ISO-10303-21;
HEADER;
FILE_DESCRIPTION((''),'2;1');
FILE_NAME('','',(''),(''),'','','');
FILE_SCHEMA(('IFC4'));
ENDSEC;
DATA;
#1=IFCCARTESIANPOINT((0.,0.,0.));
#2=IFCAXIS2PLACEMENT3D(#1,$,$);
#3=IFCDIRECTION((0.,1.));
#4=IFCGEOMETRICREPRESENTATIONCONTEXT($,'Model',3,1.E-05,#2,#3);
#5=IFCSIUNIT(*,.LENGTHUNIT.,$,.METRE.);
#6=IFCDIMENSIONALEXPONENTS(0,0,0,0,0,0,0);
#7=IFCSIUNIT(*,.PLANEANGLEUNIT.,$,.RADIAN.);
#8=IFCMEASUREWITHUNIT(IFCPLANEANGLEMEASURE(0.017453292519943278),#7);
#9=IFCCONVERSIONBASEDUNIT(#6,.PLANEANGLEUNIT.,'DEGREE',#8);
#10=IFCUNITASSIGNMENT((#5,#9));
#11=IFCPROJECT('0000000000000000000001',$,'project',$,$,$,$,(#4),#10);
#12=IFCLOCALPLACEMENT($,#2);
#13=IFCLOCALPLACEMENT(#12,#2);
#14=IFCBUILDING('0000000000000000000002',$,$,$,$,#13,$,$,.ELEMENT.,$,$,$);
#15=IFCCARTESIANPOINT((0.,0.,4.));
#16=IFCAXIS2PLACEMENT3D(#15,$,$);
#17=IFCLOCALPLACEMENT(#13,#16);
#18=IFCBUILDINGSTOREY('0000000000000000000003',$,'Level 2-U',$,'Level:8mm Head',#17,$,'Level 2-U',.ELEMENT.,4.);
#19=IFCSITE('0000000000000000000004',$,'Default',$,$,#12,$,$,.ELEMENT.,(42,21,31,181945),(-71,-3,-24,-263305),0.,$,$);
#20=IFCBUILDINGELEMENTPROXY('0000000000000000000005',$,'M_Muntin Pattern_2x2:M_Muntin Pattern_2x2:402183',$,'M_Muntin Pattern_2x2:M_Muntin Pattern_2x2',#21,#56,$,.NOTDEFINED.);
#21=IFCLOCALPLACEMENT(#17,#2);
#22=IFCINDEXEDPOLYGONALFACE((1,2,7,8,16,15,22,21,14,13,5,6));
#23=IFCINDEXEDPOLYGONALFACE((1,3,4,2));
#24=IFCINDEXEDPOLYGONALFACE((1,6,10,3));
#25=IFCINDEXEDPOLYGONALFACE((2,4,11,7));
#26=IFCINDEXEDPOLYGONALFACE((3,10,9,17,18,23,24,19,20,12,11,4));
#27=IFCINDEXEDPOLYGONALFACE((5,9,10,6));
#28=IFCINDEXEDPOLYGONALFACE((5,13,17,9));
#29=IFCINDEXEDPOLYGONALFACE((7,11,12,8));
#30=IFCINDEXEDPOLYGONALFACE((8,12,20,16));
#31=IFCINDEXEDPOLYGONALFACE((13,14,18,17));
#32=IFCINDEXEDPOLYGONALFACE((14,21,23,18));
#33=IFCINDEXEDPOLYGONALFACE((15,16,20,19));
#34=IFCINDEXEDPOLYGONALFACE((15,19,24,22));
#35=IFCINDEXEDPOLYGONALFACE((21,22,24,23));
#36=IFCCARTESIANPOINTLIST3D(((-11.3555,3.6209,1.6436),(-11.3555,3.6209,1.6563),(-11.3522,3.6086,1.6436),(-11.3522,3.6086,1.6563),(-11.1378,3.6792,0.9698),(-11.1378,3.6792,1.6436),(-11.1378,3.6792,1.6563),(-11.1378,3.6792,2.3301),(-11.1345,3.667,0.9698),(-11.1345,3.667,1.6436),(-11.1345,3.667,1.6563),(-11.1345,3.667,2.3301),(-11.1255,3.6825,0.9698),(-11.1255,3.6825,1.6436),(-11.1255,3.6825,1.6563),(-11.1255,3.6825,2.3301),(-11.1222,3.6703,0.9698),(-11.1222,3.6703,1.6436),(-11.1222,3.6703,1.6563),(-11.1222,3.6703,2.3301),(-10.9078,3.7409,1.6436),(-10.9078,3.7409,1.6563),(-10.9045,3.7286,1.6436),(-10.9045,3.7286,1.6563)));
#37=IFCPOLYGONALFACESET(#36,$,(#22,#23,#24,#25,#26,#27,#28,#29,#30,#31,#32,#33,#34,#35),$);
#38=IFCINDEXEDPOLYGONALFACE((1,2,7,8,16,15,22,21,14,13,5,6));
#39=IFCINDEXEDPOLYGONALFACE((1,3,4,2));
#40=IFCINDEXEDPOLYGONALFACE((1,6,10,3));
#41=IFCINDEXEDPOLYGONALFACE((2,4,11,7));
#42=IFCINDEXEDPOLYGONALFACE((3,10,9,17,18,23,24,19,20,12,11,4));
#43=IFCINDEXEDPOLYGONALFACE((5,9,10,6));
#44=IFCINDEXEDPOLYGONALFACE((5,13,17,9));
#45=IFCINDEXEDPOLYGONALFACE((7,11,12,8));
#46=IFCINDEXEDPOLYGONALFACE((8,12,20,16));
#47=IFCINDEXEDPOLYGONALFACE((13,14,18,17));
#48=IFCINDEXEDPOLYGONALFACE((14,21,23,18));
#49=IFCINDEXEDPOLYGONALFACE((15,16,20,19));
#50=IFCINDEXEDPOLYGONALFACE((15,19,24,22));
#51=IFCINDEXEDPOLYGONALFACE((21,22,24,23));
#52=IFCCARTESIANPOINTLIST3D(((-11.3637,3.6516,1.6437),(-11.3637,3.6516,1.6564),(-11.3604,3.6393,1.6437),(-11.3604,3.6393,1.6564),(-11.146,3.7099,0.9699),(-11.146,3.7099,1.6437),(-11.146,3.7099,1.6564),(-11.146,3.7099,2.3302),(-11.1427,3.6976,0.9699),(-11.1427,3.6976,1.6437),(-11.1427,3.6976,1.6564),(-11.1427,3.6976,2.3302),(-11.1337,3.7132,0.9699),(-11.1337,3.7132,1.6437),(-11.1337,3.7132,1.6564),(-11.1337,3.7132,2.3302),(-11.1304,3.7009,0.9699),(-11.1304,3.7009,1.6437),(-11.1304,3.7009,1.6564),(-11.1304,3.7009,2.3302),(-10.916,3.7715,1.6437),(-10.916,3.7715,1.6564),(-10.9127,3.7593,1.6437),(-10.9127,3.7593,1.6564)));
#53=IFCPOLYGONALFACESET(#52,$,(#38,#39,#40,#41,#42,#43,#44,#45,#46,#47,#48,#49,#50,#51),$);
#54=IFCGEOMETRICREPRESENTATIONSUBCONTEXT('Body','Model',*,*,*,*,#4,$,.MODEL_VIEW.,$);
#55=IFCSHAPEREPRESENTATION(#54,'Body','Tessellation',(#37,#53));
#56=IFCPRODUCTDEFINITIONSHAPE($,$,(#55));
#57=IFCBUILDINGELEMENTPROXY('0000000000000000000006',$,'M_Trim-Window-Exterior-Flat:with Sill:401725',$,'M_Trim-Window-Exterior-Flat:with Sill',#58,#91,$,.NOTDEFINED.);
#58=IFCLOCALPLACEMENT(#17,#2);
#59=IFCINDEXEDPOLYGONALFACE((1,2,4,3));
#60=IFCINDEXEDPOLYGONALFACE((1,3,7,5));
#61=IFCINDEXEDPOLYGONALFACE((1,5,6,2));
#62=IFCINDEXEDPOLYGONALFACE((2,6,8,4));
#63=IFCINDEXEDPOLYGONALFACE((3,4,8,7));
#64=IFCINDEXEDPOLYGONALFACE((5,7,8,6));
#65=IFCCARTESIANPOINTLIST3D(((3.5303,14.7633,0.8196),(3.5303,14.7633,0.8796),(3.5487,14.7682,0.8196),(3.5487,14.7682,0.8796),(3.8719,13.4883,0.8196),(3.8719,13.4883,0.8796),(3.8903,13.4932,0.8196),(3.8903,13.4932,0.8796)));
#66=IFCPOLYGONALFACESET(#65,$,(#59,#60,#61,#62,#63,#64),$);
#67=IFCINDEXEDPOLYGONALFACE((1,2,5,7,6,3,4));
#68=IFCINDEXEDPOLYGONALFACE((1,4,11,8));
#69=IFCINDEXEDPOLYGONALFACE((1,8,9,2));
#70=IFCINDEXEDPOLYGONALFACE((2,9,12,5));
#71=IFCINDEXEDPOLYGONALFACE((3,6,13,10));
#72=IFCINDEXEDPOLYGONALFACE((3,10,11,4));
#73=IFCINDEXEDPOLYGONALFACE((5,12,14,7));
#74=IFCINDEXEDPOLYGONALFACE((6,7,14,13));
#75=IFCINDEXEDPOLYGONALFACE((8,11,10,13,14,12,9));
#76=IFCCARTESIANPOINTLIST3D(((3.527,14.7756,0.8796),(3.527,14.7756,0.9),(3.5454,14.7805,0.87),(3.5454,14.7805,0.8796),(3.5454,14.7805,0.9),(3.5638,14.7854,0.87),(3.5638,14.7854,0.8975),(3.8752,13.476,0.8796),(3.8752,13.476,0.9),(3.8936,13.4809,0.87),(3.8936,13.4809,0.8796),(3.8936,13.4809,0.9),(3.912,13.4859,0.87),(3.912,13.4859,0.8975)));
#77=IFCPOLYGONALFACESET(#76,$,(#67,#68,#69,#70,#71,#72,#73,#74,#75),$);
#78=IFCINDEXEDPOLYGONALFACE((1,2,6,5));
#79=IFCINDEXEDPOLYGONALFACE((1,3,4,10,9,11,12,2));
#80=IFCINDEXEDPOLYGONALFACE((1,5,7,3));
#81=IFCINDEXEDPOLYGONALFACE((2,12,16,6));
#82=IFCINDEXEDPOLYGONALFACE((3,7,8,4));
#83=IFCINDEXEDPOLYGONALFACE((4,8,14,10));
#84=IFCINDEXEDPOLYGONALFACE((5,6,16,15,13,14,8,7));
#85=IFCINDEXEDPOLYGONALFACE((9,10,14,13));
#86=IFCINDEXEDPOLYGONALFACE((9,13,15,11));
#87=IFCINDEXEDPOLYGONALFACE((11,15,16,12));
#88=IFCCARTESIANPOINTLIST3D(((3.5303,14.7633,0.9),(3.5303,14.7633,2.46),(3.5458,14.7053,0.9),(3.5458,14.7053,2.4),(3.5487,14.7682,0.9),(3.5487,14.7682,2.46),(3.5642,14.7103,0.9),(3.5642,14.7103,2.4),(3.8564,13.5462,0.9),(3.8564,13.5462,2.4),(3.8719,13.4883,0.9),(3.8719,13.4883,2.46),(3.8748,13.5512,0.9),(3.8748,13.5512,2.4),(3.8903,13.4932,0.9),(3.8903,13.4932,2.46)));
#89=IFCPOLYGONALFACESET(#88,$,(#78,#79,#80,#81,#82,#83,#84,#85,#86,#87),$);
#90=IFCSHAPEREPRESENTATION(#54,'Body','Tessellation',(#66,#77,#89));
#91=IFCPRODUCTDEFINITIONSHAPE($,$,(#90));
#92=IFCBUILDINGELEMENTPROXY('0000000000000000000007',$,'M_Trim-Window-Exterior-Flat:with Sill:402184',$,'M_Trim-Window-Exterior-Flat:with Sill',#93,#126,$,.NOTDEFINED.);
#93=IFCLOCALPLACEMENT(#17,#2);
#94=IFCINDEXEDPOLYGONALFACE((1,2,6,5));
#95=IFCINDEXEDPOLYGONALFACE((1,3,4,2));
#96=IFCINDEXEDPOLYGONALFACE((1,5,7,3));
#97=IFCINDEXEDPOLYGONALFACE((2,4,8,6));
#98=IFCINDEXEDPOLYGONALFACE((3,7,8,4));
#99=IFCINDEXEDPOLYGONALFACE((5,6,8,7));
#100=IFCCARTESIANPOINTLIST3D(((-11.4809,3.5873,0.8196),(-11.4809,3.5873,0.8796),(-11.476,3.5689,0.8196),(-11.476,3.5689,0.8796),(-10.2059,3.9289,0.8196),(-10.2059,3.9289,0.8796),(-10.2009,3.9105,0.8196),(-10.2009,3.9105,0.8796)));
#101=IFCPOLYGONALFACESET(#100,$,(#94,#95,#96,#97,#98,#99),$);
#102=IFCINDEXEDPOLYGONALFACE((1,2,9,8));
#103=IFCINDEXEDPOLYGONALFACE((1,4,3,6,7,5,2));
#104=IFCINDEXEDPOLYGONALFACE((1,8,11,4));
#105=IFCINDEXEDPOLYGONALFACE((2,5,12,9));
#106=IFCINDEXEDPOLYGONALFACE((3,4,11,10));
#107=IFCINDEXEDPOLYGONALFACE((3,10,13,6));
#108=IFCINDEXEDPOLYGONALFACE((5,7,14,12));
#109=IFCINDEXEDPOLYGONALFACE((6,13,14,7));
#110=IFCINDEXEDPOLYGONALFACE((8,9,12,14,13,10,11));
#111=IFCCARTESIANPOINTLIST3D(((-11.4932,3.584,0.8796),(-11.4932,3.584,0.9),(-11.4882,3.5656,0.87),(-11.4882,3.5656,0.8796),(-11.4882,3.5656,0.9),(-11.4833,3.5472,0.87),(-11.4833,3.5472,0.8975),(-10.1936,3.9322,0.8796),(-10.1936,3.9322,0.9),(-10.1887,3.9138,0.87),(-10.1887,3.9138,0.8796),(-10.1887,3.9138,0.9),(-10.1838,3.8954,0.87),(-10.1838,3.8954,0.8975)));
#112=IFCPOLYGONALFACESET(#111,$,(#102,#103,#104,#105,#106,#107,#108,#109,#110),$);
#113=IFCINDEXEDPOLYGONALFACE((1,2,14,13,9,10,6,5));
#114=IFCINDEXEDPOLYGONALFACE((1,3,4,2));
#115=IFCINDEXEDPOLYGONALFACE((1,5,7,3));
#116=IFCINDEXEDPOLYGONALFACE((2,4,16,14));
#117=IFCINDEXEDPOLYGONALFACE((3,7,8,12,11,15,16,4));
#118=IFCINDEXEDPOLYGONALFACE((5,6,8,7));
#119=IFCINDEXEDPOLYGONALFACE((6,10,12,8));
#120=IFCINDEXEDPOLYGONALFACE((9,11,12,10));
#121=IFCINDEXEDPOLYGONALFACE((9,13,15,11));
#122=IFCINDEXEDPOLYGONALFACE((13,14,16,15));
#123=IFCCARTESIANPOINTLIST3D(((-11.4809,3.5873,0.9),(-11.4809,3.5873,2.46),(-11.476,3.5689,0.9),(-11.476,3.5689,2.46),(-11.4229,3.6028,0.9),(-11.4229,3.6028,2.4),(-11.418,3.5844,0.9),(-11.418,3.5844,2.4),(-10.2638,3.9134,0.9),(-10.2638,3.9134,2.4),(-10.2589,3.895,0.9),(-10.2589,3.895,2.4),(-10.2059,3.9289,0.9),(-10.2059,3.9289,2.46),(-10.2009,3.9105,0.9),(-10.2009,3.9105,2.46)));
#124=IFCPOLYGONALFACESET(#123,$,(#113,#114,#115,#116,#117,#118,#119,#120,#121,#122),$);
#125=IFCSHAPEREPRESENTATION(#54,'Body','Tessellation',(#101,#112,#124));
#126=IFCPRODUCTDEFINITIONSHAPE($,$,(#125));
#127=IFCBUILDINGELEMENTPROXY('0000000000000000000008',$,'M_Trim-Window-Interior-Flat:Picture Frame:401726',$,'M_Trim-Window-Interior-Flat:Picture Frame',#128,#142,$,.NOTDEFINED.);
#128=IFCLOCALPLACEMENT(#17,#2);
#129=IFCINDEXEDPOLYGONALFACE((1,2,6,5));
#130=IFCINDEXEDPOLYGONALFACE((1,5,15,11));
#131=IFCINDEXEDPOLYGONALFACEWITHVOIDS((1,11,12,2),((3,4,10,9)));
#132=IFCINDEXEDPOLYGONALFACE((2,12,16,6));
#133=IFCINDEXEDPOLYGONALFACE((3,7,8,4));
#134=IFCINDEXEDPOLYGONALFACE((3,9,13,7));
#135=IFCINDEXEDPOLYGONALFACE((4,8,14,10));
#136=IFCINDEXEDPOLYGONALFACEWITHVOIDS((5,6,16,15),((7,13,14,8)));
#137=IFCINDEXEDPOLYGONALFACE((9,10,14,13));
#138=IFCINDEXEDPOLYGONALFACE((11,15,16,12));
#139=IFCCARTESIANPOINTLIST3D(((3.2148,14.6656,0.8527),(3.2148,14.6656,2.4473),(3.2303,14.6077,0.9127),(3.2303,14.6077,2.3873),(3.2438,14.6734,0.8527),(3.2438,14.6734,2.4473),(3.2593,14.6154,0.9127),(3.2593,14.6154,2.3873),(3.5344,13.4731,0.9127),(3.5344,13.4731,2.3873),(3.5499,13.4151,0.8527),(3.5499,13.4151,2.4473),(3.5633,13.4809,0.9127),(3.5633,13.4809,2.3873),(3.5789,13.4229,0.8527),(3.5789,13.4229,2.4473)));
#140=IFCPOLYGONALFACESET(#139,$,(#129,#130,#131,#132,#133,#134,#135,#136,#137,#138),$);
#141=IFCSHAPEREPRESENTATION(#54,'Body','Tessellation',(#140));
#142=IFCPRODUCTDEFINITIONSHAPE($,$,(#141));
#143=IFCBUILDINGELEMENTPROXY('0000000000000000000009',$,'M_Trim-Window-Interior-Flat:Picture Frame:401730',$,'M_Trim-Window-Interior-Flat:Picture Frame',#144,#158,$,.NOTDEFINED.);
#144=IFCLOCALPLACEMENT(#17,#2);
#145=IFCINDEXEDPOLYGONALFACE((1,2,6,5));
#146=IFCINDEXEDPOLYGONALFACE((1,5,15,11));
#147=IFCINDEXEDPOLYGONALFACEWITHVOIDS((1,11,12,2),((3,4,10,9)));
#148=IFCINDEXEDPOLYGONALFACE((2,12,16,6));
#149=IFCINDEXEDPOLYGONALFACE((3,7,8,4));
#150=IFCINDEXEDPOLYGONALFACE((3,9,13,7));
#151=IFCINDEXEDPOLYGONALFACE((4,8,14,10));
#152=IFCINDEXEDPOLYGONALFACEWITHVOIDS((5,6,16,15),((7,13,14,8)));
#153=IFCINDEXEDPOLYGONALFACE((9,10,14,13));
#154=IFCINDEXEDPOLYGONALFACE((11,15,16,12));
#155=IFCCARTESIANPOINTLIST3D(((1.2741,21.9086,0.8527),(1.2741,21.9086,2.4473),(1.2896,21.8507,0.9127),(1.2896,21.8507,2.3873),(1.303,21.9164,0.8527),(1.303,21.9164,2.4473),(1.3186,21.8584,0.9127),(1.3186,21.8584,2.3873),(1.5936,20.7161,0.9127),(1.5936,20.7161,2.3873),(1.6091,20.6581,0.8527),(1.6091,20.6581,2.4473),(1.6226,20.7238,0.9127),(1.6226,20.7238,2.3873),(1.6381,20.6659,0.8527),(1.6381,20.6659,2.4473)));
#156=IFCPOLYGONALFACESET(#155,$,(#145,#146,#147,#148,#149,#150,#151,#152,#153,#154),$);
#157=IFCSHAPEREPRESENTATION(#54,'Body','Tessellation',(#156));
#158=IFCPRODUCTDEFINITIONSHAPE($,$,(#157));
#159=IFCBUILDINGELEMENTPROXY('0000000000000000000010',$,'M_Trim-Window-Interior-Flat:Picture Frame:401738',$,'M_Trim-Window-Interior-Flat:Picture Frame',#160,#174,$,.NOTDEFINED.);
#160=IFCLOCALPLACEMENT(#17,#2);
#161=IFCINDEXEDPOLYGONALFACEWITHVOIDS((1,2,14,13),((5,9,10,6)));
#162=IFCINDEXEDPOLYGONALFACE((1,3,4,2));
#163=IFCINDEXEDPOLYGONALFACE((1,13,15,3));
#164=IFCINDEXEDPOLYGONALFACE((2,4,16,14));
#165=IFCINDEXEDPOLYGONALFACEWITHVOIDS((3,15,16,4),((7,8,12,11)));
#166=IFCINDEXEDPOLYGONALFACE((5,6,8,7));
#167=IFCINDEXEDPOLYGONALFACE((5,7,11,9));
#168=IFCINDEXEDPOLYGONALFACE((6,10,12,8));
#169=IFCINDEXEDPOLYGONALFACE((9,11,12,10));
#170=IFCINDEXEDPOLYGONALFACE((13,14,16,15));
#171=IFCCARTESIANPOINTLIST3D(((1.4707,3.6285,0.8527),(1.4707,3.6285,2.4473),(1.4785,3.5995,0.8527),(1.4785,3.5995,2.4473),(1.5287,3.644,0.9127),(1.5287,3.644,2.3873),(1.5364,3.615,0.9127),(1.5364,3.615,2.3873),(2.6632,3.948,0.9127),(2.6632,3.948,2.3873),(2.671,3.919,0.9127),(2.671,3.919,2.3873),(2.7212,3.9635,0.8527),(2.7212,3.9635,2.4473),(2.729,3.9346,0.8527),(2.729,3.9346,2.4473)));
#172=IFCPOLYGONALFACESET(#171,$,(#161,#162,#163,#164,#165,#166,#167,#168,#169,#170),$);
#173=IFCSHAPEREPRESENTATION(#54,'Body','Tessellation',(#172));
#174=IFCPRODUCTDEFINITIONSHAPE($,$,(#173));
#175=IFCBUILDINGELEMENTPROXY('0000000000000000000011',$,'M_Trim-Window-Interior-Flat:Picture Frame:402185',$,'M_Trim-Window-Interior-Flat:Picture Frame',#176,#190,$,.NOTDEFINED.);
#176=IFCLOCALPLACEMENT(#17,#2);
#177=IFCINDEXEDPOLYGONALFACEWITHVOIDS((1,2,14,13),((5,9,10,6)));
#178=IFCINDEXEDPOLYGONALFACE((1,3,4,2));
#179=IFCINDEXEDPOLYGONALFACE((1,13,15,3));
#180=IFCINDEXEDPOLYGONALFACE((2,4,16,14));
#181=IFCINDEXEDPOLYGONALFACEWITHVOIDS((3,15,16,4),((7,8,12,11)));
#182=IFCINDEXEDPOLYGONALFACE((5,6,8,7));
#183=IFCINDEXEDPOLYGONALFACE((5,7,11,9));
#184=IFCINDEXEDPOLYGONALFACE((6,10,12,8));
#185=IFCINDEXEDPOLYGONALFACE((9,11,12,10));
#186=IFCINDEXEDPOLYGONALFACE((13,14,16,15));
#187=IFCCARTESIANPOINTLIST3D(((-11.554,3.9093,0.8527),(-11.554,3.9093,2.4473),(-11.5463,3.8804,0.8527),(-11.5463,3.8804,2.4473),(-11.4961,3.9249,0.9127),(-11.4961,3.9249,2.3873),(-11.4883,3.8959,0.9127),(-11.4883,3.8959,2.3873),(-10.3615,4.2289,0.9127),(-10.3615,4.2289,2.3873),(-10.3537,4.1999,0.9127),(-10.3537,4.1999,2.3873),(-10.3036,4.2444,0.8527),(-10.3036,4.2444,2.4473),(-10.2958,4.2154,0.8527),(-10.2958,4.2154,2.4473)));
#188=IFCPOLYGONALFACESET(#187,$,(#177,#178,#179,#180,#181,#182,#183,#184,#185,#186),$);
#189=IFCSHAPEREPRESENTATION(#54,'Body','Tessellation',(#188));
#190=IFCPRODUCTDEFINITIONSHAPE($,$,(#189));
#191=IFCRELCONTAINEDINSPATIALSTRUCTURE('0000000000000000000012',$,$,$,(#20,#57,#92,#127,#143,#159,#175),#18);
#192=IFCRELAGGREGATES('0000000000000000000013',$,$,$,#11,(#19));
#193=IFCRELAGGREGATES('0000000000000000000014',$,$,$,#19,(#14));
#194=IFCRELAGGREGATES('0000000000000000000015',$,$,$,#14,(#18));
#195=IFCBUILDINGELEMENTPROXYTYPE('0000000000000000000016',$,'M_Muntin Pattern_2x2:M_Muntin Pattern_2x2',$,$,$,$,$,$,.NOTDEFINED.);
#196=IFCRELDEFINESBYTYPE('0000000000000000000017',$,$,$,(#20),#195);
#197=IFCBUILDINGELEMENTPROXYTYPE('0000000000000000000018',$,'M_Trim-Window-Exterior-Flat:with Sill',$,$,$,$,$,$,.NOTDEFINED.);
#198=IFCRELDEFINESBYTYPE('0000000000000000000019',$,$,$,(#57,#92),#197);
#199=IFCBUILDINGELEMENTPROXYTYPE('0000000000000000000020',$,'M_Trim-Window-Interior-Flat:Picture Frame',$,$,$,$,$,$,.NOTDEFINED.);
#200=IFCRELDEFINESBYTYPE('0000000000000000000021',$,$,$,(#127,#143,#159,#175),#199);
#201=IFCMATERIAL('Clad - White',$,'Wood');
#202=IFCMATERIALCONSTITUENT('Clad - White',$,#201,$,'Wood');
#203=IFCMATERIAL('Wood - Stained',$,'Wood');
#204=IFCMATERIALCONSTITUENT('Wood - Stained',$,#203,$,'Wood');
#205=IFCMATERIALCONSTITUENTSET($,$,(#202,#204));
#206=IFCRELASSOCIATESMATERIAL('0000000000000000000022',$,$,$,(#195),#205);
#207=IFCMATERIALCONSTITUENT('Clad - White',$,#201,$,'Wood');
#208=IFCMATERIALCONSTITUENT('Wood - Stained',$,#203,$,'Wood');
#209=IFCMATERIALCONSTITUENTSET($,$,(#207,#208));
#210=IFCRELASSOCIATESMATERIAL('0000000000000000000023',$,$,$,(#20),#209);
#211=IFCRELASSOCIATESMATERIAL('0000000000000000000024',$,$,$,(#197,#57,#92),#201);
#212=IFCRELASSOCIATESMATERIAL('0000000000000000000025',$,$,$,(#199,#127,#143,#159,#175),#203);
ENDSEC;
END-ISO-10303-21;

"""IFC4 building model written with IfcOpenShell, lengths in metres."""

from ifc_helpers import new_model, entity, si_unit, converted_unit, direction, frame, origin, place, context, subcontext, project, spatial, indexed_curve, outline, extrude, source, transform, mapped, material, constituent, constituent_set, type_object, type_shapes, element, save


model = new_model("IFC4")

# Units and contexts
model_context = context("Model", 3, precision=1e-05, world=origin(), true_north=direction((0.0, 1.0)))
body_context = subcontext(model_context, "Body", "Model", "MODEL_VIEW")
ifc_project = project(units=[si_unit("LENGTHUNIT", "METRE"), converted_unit("PLANEANGLEUNIT", "DEGREE", entity("IfcPlaneAngleMeasure", 0.017453292519943278), si_unit("PLANEANGLEUNIT", "RADIAN"), dimensions=[0, 0, 0, 0, 0, 0, 0])], contexts=[model_context])

# Site, building, storey
site_placement = place(None, origin())
site = spatial("IfcSite", under=ifc_project, at=site_placement, Name="Default", CompositionType="ELEMENT", RefLatitude=(42, 21, 31, 181945), RefLongitude=(-71, -3, -24, -263305), RefElevation=0.0)
building_placement = place(site_placement, origin())
building = spatial("IfcBuilding", under=site, at=building_placement, CompositionType="ELEMENT")
storey_placement = place(building_placement, frame((0.0, 0.0, 4.0)))
storey = spatial("IfcBuildingStorey", under=building, at=storey_placement, Name="Level 2-U", ObjectType="Level:8mm Head", LongName="Level 2-U", CompositionType="ELEMENT", Elevation=4.0)

# Building element proxies
ifc_material_1 = material(Name="Clad - White", Category="Wood")
ifc_material_2 = material(Name="Wood - Stained", Category="Wood")
ifc_constituent_1 = constituent(ifc_material_1, Name="Clad - White", Category="Wood")
ifc_constituent_2 = constituent(ifc_material_2, Name="Wood - Stained", Category="Wood")
ifc_constituent_set_1 = constituent_set(constituents=[ifc_constituent_1, ifc_constituent_2])
building_element_proxy_type_1 = type_object("IfcBuildingElementProxyType", Name="M_Muntin Pattern_2x2:M_Muntin Pattern_2x2", PredefinedType="NOTDEFINED", material=ifc_constituent_set_1)
shared_shape_1 = source(origin(), body_context, "Body", "SweptSolid", [
    extrude(outline(indexed_curve([(0.0064, -0.0064), (0.6801, -0.0064), (0.6801, 0.0063), (0.0064, 0.0063), (0.0064, 0.2317), (-0.0063, 0.2317), (-0.0063, 0.0063), (-0.6802, 0.0063), (-0.6802, -0.0064), (-0.0063, -0.0064), (-0.0063, -0.2317), (0.0064, -0.2317), (0.0064, -0.0064)], self_intersect=False)), frame((0.0, -0.0222, 0.6801), z_axis=(0.0, 1.0, 0.0), x_axis=(0.0, 0.0, 1.0)), (0.0, 0.0, 1.0), 0.0127),
    extrude(outline(indexed_curve([(0.0064, -0.0064), (0.6802, -0.0064), (0.6802, 0.0063), (0.0064, 0.0063), (0.0064, 0.2317), (-0.0063, 0.2317), (-0.0063, 0.0063), (-0.6802, 0.0063), (-0.6802, -0.0064), (-0.0063, -0.0064), (-0.0063, -0.2317), (0.0064, -0.2317), (0.0064, -0.0064)], self_intersect=False)), frame((0.0, 0.0095, 0.6802), z_axis=(0.0, 1.0, 0.0), x_axis=(0.0, 0.0, 1.0)), (0.0, 0.0, 1.0), 0.0127),
])
type_shapes(building_element_proxy_type_1, [shared_shape_1])
ifc_constituent_3 = constituent(ifc_material_1, Name="Clad - White", Category="Wood")
ifc_constituent_4 = constituent(ifc_material_2, Name="Wood - Stained", Category="Wood")
ifc_constituent_set_2 = constituent_set(constituents=[ifc_constituent_3, ifc_constituent_4])
proxy_1_placement = place(storey_placement, frame((-11.1341, 3.6901, 0.9699), z_axis=(0.0, 0.0, 1.0), x_axis=(0.965926, 0.258819, 0.0)))
element("IfcBuildingElementProxy", 1, at=proxy_1_placement, inside=storey, type_object=building_element_proxy_type_1, material=ifc_constituent_set_2, Name="M_Muntin Pattern_2x2:M_Muntin Pattern_2x2:402183", ObjectType="M_Muntin Pattern_2x2:M_Muntin Pattern_2x2", PredefinedType="NOTDEFINED", context=body_context, shape_type="MappedRepresentation", body=[
    mapped(shared_shape_1, transform((0.0, 0.0, 0.0), scale=1.0)),
])
building_element_proxy_type_2 = type_object("IfcBuildingElementProxyType", Name="M_Trim-Window-Exterior-Flat:with Sill", PredefinedType="NOTDEFINED", material=ifc_material_1)
shared_shape_2 = source(origin(), body_context, "Body", "SweptSolid", [
    extrude(outline(indexed_curve([(-0.66, -0.03), (0.66, -0.03), (0.66, 0.03), (-0.66, 0.03), (-0.66, -0.03)], self_intersect=False)), frame((0.0, -1.5504, 0.0), z_axis=(0.0, 0.0, 1.0), x_axis=(-1.0, 0.0, 0.0)), (0.0, 0.0, 1.0), 0.019),
    extrude(outline(indexed_curve([(-0.019, -0.0152), (0.0, -0.0152), (0.0, -0.0057), (0.019, -0.0057), (0.019, 0.0148), (0.0, 0.0148), (-0.019, 0.0123), (-0.019, -0.0152)], self_intersect=False)), frame((-0.6727, -1.5148, 0.019), z_axis=(1.0, 0.0, 0.0), x_axis=(0.0, 0.0, -1.0)), (0.0, 0.0, 1.0), 1.3454),
    extrude(outline(indexed_curve([(-0.795, -0.66), (0.765, -0.66), (0.765, -0.6), (-0.735, -0.6), (-0.735, 0.6), (0.765, 0.6), (0.765, 0.66), (-0.795, 0.66), (-0.795, -0.66)], self_intersect=False)), frame((0.0, -0.735, 0.0), z_axis=(0.0, 0.0, 1.0), x_axis=(0.0, -1.0, 0.0)), (0.0, 0.0, 1.0), 0.019),
])
type_shapes(building_element_proxy_type_2, [shared_shape_2])
for number, where, z_axis, x_axis, name in (
    (2, (3.7011, 14.1258, 2.4), (0.965926, 0.258819, 0.0), (-0.258819, 0.965926, 0.0), "M_Trim-Window-Exterior-Flat:with Sill:401725"),
    (3, (-10.8434, 3.7581, 2.4), (0.258819, -0.965926, 0.0), (0.965926, 0.258819, 0.0), "M_Trim-Window-Exterior-Flat:with Sill:402184"),
):
    element("IfcBuildingElementProxy", number, at=place(storey_placement, frame(where, z_axis=z_axis, x_axis=x_axis)), inside=storey, type_object=building_element_proxy_type_2, material=ifc_material_1, Name=name, ObjectType="M_Trim-Window-Exterior-Flat:with Sill", PredefinedType="NOTDEFINED", context=body_context, shape_type="MappedRepresentation", body=[
        mapped(shared_shape_2, transform((0.0, 0.0, 0.0), scale=1.0)),
    ])
building_element_proxy_type_3 = type_object("IfcBuildingElementProxyType", Name="M_Trim-Window-Interior-Flat:Picture Frame", PredefinedType="NOTDEFINED", material=ifc_material_2)
shared_shape_3 = source(origin(), body_context, "Body", "SweptSolid", [
    extrude(outline(indexed_curve([(-0.6473, -0.7973), (0.6473, -0.7973), (0.6473, 0.7973), (-0.6473, 0.7973), (-0.6473, -0.7973)], self_intersect=False), holes=[indexed_curve([(-0.5873, -0.7373), (-0.5873, 0.7373), (0.5873, 0.7373), (0.5873, -0.7373), (-0.5873, -0.7373)], self_intersect=False)]), frame((0.0, -0.75, 0.0), z_axis=(0.0, 0.0, 1.0), x_axis=(-1.0, 0.0, 0.0)), (0.0, 0.0, 1.0), 0.03),
])
type_shapes(building_element_proxy_type_3, [shared_shape_3])
for number, where, z_axis, x_axis, name in (
    (4, (3.4113, 14.0481, 2.4), (-0.965926, -0.258819, 0.0), (0.258819, -0.965926, 0.0), "M_Trim-Window-Interior-Flat:Picture Frame:401726"),
    (5, (1.4706, 21.2911, 2.4), (-0.965926, -0.258819, 0.0), (0.258819, -0.965926, 0.0), "M_Trim-Window-Interior-Flat:Picture Frame:401730"),
    (6, (2.1037, 3.767, 2.4), (-0.258819, 0.965926, 0.0), (-0.965926, -0.258819, 0.0), "M_Trim-Window-Interior-Flat:Picture Frame:401738"),
    (7, (-10.921, 4.0479, 2.4), (-0.258819, 0.965926, 0.0), (-0.965926, -0.258819, 0.0), "M_Trim-Window-Interior-Flat:Picture Frame:402185"),
):
    element("IfcBuildingElementProxy", number, at=place(storey_placement, frame(where, z_axis=z_axis, x_axis=x_axis)), inside=storey, type_object=building_element_proxy_type_3, material=ifc_material_2, Name=name, ObjectType="M_Trim-Window-Interior-Flat:Picture Frame", PredefinedType="NOTDEFINED", context=body_context, shape_type="MappedRepresentation", body=[
        mapped(shared_shape_3, transform((0.0, 0.0, 0.0), scale=1.0)),
    ])

save(model, "model.ifc")
